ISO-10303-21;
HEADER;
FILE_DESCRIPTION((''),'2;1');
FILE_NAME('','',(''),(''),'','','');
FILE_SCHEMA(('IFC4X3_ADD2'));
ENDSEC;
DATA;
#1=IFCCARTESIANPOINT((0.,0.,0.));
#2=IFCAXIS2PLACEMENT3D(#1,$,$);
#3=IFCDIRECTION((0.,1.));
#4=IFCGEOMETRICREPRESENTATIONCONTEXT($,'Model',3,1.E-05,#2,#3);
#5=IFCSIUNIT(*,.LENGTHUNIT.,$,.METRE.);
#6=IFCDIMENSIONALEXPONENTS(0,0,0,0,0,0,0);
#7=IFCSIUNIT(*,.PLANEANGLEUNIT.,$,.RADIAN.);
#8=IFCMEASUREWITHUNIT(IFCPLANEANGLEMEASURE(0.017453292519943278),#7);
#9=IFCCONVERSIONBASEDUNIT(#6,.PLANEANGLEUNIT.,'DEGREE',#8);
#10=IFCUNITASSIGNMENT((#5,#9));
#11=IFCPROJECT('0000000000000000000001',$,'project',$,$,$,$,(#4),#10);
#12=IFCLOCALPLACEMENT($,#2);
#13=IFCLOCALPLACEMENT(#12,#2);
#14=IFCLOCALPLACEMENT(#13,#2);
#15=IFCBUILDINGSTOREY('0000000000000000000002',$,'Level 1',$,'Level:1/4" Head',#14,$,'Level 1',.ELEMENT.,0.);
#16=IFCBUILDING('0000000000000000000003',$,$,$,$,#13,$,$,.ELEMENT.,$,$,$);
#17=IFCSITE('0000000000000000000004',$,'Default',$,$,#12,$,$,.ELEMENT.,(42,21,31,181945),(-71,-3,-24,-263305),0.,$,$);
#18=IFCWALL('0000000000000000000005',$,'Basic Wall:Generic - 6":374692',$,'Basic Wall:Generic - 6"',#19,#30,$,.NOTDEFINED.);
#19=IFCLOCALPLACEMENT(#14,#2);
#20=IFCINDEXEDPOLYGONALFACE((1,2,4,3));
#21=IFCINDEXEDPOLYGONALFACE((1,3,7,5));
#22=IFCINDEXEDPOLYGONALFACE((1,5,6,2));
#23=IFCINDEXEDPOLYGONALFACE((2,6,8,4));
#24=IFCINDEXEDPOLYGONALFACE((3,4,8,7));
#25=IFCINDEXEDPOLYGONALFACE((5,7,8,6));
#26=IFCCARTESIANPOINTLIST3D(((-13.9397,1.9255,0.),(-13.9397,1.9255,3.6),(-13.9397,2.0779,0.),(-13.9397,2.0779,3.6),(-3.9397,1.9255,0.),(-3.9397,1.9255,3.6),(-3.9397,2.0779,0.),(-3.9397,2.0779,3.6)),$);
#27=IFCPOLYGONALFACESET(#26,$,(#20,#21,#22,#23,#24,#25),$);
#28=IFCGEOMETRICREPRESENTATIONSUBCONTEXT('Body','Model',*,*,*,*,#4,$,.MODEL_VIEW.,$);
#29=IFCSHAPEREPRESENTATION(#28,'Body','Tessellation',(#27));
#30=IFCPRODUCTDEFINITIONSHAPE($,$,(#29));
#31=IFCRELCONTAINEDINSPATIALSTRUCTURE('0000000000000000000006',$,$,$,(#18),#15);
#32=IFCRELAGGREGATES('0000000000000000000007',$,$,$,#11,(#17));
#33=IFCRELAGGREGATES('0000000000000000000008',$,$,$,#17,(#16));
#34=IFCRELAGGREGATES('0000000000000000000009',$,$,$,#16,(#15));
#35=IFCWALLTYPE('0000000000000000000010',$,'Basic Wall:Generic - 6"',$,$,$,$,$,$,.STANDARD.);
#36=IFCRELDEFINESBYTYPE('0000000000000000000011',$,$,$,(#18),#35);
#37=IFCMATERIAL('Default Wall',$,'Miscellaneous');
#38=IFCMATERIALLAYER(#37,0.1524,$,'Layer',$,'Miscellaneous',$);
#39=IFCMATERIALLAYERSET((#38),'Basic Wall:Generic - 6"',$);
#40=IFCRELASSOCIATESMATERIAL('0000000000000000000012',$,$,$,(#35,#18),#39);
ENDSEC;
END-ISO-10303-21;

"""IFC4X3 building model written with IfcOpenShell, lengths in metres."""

from ifc_helpers import new_model, entity, si_unit, converted_unit, direction, frame, frame_2d, origin, place, context, subcontext, project, spatial, rectangle, extrude, material, layer, layer_set, type_object, element, save


model = new_model("IFC4X3")

# Units and contexts
model_context = context("Model", 3, precision=1e-05, world=origin(), true_north=direction((0.0, 1.0)))
body_context = subcontext(model_context, "Body", "Model", "MODEL_VIEW")
ifc_project = project(units=[si_unit("LENGTHUNIT", "METRE"), converted_unit("PLANEANGLEUNIT", "DEGREE", entity("IfcPlaneAngleMeasure", 0.017453292519943278), si_unit("PLANEANGLEUNIT", "RADIAN"), dimensions=[0, 0, 0, 0, 0, 0, 0])], contexts=[model_context])

# Site, building, storey
site_placement = place(None, origin())
site = spatial("IfcSite", under=ifc_project, at=site_placement, Name="Default", CompositionType="ELEMENT", RefLatitude=(42, 21, 31, 181945), RefLongitude=(-71, -3, -24, -263305), RefElevation=0.0)
building_placement = place(site_placement, origin())
building = spatial("IfcBuilding", under=site, at=building_placement, CompositionType="ELEMENT")
storey_placement = place(building_placement, origin())
storey = spatial("IfcBuildingStorey", under=building, at=storey_placement, Name="Level 1", ObjectType="Level:1/4\" Head", LongName="Level 1", CompositionType="ELEMENT", Elevation=0.0)

# Wall
ifc_material_1 = material(Name="Default Wall", Category="Miscellaneous")
ifc_layer_1 = layer(ifc_material_1, 0.1524, Name="Layer", Category="Miscellaneous")
ifc_layer_set_1 = layer_set([ifc_layer_1], Name="Basic Wall:Generic - 6\"")
wall_type_1 = type_object("IfcWallType", Name="Basic Wall:Generic - 6\"", PredefinedType="STANDARD", material=ifc_layer_set_1)
wall_1_placement = place(storey_placement, frame((-13.9397, 2.0017, 0.0)))
element("IfcWall", 1, at=wall_1_placement, inside=storey, type_object=wall_type_1, material=ifc_layer_set_1, Name="Basic Wall:Generic - 6\":374692", ObjectType="Basic Wall:Generic - 6\"", PredefinedType="NOTDEFINED", context=body_context, shape_type="SweptSolid", body=[
    extrude(rectangle(XDim=10.0, YDim=0.1524, at=frame_2d((5.0, 0.0), x_axis=(-1.0, 0.0))), origin(), (0.0, 0.0, 1.0), 3.6),
])

save(model, "model.ifc")
